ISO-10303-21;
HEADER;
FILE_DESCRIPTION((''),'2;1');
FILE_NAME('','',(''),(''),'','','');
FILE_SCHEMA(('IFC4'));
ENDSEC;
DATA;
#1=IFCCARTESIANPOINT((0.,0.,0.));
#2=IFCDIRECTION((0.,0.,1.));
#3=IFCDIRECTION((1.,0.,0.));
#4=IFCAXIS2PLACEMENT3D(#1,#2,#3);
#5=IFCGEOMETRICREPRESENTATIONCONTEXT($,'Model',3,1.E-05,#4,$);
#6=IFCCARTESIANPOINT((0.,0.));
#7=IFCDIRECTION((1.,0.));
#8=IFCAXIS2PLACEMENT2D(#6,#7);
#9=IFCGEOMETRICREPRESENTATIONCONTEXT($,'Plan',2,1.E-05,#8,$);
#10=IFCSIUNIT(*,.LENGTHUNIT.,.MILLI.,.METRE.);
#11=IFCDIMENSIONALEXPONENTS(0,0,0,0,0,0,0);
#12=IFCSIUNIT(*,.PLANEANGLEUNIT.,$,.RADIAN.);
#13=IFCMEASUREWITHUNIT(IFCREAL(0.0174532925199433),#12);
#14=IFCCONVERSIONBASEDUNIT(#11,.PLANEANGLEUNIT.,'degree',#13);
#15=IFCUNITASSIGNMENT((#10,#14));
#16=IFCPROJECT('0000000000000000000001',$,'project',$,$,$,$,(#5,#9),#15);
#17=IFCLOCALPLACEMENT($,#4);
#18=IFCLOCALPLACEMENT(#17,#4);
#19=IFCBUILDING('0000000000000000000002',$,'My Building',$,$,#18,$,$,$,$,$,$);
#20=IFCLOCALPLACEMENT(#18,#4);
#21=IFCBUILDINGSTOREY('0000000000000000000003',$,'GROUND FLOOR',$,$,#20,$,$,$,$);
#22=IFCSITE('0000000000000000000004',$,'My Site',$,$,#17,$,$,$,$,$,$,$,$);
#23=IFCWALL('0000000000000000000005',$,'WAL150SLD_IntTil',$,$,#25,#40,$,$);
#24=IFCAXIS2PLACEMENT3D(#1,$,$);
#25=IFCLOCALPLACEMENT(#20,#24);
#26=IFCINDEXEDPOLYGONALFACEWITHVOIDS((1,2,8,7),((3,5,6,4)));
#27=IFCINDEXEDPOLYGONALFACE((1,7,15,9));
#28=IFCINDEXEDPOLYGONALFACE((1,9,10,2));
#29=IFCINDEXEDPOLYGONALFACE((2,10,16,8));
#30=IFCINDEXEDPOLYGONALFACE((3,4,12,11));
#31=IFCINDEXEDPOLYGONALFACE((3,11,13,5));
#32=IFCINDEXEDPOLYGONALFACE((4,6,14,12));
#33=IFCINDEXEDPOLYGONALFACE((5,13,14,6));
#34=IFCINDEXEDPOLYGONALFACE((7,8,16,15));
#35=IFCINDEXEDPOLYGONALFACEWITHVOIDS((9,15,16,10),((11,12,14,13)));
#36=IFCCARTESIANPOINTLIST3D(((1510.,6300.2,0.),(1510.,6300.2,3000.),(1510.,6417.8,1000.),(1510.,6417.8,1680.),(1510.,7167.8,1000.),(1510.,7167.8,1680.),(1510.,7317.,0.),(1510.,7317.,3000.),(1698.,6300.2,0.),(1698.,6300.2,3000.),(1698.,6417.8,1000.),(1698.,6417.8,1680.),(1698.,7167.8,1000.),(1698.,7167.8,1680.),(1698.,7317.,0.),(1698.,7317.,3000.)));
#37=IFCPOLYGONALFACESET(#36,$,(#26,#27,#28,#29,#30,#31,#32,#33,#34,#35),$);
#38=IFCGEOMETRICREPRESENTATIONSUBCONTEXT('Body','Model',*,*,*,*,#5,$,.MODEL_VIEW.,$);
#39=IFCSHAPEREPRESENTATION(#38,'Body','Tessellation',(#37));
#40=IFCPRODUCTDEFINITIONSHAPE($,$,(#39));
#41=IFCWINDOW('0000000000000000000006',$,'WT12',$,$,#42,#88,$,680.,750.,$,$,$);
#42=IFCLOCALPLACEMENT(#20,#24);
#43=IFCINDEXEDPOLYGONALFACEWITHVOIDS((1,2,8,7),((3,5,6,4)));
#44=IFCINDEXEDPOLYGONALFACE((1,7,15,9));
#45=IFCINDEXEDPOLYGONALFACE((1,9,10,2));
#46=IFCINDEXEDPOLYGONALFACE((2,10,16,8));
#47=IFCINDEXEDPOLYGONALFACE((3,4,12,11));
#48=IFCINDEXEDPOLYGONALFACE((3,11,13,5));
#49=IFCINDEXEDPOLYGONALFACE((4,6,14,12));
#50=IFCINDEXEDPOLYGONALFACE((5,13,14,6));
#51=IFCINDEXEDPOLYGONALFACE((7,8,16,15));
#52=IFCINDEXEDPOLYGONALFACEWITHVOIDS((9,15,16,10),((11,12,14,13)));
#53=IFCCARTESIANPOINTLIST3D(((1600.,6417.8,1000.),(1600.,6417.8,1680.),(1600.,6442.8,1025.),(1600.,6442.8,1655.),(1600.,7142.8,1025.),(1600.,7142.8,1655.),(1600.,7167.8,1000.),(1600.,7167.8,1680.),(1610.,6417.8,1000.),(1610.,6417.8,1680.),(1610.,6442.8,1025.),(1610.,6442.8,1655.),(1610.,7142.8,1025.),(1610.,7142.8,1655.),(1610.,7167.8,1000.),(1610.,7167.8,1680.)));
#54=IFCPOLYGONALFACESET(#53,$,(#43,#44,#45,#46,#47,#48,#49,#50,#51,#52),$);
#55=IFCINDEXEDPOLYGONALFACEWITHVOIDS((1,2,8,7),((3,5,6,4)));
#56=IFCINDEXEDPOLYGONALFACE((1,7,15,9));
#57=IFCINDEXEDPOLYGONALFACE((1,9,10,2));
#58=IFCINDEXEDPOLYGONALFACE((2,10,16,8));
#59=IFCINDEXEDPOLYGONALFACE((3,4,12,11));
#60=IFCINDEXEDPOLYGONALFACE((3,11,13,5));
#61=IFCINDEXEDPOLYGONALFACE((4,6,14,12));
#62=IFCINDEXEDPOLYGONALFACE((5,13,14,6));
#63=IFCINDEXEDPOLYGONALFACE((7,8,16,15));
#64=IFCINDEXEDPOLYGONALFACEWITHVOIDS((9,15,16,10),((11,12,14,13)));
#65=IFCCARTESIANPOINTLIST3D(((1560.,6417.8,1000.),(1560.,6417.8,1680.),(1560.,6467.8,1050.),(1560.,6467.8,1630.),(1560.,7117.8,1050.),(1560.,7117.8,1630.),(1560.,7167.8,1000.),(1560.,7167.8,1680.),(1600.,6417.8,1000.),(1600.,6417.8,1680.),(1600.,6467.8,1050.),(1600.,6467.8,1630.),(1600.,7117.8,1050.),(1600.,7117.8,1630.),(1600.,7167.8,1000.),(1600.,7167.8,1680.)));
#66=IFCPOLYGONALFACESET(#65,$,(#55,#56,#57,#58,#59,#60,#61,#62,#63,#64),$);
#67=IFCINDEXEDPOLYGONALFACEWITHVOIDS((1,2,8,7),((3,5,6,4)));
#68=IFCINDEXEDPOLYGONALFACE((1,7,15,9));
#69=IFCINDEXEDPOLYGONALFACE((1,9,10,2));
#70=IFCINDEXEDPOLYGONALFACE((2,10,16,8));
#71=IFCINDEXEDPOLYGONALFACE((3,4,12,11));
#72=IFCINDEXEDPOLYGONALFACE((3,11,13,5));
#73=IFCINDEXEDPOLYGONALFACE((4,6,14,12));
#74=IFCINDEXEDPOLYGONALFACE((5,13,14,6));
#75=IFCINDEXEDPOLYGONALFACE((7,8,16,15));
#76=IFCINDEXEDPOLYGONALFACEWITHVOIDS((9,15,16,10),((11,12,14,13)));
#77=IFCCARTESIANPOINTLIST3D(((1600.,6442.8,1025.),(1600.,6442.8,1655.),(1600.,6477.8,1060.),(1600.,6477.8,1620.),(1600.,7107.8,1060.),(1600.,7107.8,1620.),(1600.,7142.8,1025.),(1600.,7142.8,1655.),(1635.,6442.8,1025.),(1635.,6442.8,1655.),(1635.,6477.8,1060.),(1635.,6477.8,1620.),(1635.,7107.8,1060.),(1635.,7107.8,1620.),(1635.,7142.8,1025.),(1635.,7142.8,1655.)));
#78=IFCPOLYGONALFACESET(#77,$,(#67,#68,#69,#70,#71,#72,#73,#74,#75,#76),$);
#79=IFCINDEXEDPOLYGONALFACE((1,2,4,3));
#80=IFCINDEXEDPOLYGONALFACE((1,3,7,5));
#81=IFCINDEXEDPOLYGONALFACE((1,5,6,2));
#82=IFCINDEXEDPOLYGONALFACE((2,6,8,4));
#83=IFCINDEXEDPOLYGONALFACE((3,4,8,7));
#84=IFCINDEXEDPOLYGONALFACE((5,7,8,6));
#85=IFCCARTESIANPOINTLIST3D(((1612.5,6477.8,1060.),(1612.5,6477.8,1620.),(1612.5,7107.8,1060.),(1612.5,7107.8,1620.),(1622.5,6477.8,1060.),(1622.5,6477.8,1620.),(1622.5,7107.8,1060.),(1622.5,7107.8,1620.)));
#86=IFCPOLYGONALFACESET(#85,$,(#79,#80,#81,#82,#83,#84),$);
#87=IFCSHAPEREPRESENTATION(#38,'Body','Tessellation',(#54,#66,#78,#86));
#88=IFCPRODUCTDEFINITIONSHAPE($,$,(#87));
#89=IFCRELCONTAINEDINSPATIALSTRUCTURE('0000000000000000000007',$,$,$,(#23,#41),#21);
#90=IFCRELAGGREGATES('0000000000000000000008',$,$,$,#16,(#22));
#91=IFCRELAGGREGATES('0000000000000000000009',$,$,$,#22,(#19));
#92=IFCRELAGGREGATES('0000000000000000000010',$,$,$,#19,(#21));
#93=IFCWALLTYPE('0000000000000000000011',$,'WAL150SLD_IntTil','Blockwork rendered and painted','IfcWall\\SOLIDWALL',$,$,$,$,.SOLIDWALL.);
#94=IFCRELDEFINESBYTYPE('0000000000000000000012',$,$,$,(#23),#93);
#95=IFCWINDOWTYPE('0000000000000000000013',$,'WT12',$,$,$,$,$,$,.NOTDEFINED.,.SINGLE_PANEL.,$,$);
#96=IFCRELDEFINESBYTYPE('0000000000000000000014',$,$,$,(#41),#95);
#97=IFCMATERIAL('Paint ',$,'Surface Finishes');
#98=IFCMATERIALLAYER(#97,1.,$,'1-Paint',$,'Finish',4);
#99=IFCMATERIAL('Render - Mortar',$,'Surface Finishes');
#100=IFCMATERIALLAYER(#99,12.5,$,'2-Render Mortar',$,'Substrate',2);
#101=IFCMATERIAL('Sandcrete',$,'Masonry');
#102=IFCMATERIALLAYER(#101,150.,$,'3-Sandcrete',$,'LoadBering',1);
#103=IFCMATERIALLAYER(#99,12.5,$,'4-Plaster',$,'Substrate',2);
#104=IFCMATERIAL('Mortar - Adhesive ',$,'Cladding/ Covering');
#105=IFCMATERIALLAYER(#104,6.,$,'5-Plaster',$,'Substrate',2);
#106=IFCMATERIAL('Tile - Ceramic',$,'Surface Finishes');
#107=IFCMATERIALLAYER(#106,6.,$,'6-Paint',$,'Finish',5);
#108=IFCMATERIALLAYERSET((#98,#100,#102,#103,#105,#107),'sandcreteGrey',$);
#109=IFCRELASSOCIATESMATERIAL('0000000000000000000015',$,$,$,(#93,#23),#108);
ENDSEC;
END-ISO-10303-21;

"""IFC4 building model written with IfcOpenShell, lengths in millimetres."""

from ifc_helpers import new_model, entity, si_unit, converted_unit, frame, origin_with_axes, origin_2d_with_axis, place, context, subcontext, project, spatial, line, indexed_curve, outline, extrude, shape, source, transform, mapped, material, layer, layer_set, layer_usage, type_object, type_shapes, element, fill, save


model = new_model("IFC4")

# Units and contexts
model_context = context("Model", 3, precision=1e-05, world=origin_with_axes())
plan_context = context("Plan", 2, precision=1e-05, world=origin_2d_with_axis())
body_context_1 = subcontext(model_context, "Body", "Model", "MODEL_VIEW")
body_context_2 = subcontext(plan_context, "Body", "Plan", "PLAN_VIEW")
ifc_project = project(units=[si_unit("LENGTHUNIT", "METRE", prefix="MILLI"), converted_unit("PLANEANGLEUNIT", "degree", entity("IfcReal", 0.0174532925199433), si_unit("PLANEANGLEUNIT", "RADIAN"), dimensions=[0, 0, 0, 0, 0, 0, 0])], contexts=[model_context, plan_context])

# Site, building, storey
site_placement = place(None, origin_with_axes())
site = spatial("IfcSite", under=ifc_project, at=site_placement, Name="My Site")
building_placement = place(site_placement, origin_with_axes())
building = spatial("IfcBuilding", under=site, at=building_placement, Name="My Building")
storey_placement = place(building_placement, origin_with_axes())
storey = spatial("IfcBuildingStorey", under=building, at=storey_placement, Name="GROUND FLOOR")

# Shared definitions
ifc_material_1 = material(Name="Paint ", Category="Surface Finishes")
ifc_material_2 = material(Name="Render - Mortar", Category="Surface Finishes")
ifc_material_3 = material(Name="Sandcrete", Category="Masonry")
ifc_material_4 = material(Name="Mortar - Adhesive ", Category="Cladding/ Covering")
ifc_material_5 = material(Name="Tile - Ceramic", Category="Surface Finishes")

# Wall, opening, window
ifc_layer_1 = layer(ifc_material_1, 1.0, Name="1-Paint", Category="Finish", Priority=4)
ifc_layer_2 = layer(ifc_material_2, 12.5, Name="2-Render Mortar", Category="Substrate", Priority=2)
ifc_layer_3 = layer(ifc_material_3, 150.0, Name="3-Sandcrete", Category="LoadBering", Priority=1)
ifc_layer_4 = layer(ifc_material_2, 12.5, Name="4-Plaster", Category="Substrate", Priority=2)
ifc_layer_5 = layer(ifc_material_4, 6.0, Name="5-Plaster", Category="Substrate", Priority=2)
ifc_layer_6 = layer(ifc_material_5, 6.0, Name="6-Paint", Category="Finish", Priority=5)
ifc_layer_set_1 = layer_set([ifc_layer_1, ifc_layer_2, ifc_layer_3, ifc_layer_4, ifc_layer_5, ifc_layer_6], Name="sandcreteGrey")
ifc_layer_usage_1 = layer_usage(ifc_layer_set_1, "AXIS2", "POSITIVE", 0.0)
wall_type_1 = type_object("IfcWallType", Name="WAL150SLD_IntTil", Description="Blockwork rendered and painted", ApplicableOccurrence="IfcWall\\SOLIDWALL", PredefinedType="SOLIDWALL", material=ifc_layer_set_1)
wall_1_placement = place(storey_placement, frame((1510.0, 7317.0, 0.0), z_axis=(0.0, 0.0, 1.0), x_axis=(-0.000001, -1.0, 0.0)))
wall_1 = element("IfcWall", 1, at=wall_1_placement, inside=storey, type_object=wall_type_1, material=ifc_layer_usage_1, Name="WAL150SLD_IntTil", context=body_context_1, shape_type="SweptSolid", body=[
    extrude(outline(indexed_curve([(0.0, 0.0), (0.0, 188.0), (1016.8, 188.0), (1016.8, 0.0), (0.0, 0.0)], self_intersect=False)), origin_with_axes(), (0.0, 0.0, 1.0), 3000.0),
])
shared_shape_1 = source(origin_with_axes(), body_context_1, "Body", "SweptSolid", [
    extrude(outline(indexed_curve([(0.0, 0.0), (750.0, 0.0), (750.0, 680.0), (0.0, 680.0)], segments=[line(1, 2, 3, 4, 1)])), frame((0.0, -600.0, 0.0), z_axis=(0.0, -1.0, 0.0), x_axis=(1.0, 0.0, 0.0)), (0.0, 0.0, -1.0), 1200.0),
])
opening_1_placement = place(wall_1_placement, frame((149.2, 0.0, 1000.0), z_axis=(0.0, 0.0, 1.0), x_axis=(1.0, 0.0, 0.0)))
opening_1 = element("IfcOpeningElement", 2, at=opening_1_placement, cuts=wall_1, PredefinedType="OPENING", context=body_context_1, shape_type="MappedRepresentation", body=[
    mapped(shared_shape_1, transform((0.0, 0.0, 0.0), x_axis=(1.0, 0.0, 0.0), y_axis=(0.0, 1.0, 0.0), z_axis=(0.0, 0.0, 1.0), scale=1.0)),
])
window_type_1 = type_object("IfcWindowType", Name="WT12", PartitioningType="SINGLE_PANEL", PredefinedType="NOTDEFINED")
shared_shape_2 = source(origin_with_axes(), body_context_1, "Body", "SweptSolid", [
    extrude(outline(indexed_curve([(0.0, 0.0), (750.0, 0.0), (750.0, 680.0), (0.0, 680.0)], segments=[line(1, 2, 3, 4, 1)]), holes=[indexed_curve([(25.0, 25.0), (725.0, 25.0), (725.0, 655.0), (25.0, 655.0)], segments=[line(1, 2, 3, 4, 1)])]), frame((0.0, 90.0, 0.0), z_axis=(0.0, -1.0, 0.0), x_axis=(1.0, 0.0, 0.0)), (0.0, 0.0, -1.0), 10.0),
    extrude(outline(indexed_curve([(0.0, 0.0), (750.0, 0.0), (750.0, 680.0), (0.0, 680.0)], segments=[line(1, 2, 3, 4, 1)]), holes=[indexed_curve([(50.0, 50.0), (700.0, 50.0), (700.0, 630.0), (50.0, 630.0)], segments=[line(1, 2, 3, 4, 1)])]), frame((0.0, 50.0, 0.0), z_axis=(0.0, -1.0, 0.0), x_axis=(1.0, 0.0, 0.0)), (0.0, 0.0, -1.0), 40.0),
    extrude(outline(indexed_curve([(0.0, 0.0), (700.0, 0.0), (700.0, 630.0), (0.0, 630.0)], segments=[line(1, 2, 3, 4, 1)]), holes=[indexed_curve([(35.0, 35.0), (665.0, 35.0), (665.0, 595.0), (35.0, 595.0)], segments=[line(1, 2, 3, 4, 1)])]), frame((25.0, 90.0, 25.0), z_axis=(0.0, -1.0, 0.0), x_axis=(1.0, 0.0, 0.0)), (0.0, 0.0, -1.0), 35.0),
    extrude(outline(indexed_curve([(35.0, 35.0), (665.0, 35.0), (665.0, 595.0), (35.0, 595.0)], segments=[line(1, 2, 3, 4, 1)])), frame((25.0, 102.5, 25.0), z_axis=(0.0, -1.0, 0.0), x_axis=(1.0, 0.0, 0.0)), (0.0, 0.0, -1.0), 10.0),
])
shared_shape_3 = source(origin_with_axes(), body_context_2, "Body", "Curve2D", [
    entity("IfcIndexedPolyCurve", entity("IfcCartesianPointList2D", [[50.0, 50.0], [700.0, 50.0]])),
    entity("IfcIndexedPolyCurve", entity("IfcCartesianPointList2D", [[0.0, 100.0], [25.0, 100.0], [25.0, 90.0], [50.0, 90.0], [50.0, 50.0], [0.0, 50.0]]), [entity("IfcLineIndex", [1, 2, 3, 4, 5, 6, 1])]),
    entity("IfcIndexedPolyCurve", entity("IfcCartesianPointList2D", [[750.0, 100.0], [725.0, 100.0], [725.0, 90.0], [700.0, 90.0], [700.0, 50.0], [750.0, 50.0]]), [entity("IfcLineIndex", [1, 2, 3, 4, 5, 6, 1])]),
    entity("IfcIndexedPolyCurve", entity("IfcCartesianPointList2D", [[25.0, 90.0], [60.0, 90.0], [60.0, 125.0], [25.0, 125.0]]), [entity("IfcLineIndex", [1, 2, 3, 4, 1])]),
    entity("IfcIndexedPolyCurve", entity("IfcCartesianPointList2D", [[725.0, 90.0], [690.0, 90.0], [690.0, 125.0], [725.0, 125.0]]), [entity("IfcLineIndex", [1, 2, 3, 4, 1])]),
    entity("IfcIndexedPolyCurve", entity("IfcCartesianPointList2D", [[60.0, 90.0], [690.0, 90.0]])),
    entity("IfcIndexedPolyCurve", entity("IfcCartesianPointList2D", [[60.0, 125.0], [690.0, 125.0]])),
    entity("IfcIndexedPolyCurve", entity("IfcCartesianPointList2D", [[60.0, 107.5], [690.0, 107.5]])),
])
type_shapes(window_type_1, [shared_shape_2, shared_shape_3])
window_1_placement = place(opening_1_placement, frame((0.0, 0.0, 0.0), z_axis=(0.0, 0.0, 1.0), x_axis=(1.0, 0.0, 0.0)))
window_1 = element("IfcWindow", 3, at=window_1_placement, inside=storey, type_object=window_type_1, Name="WT12", OverallHeight=680.0, OverallWidth=750.0, shapes=[
    shape(body_context_1, "Body", "MappedRepresentation", [mapped(shared_shape_2, transform((0.0, 0.0, 0.0), x_axis=(1.0, 0.0, 0.0), y_axis=(0.0, 1.0, 0.0), z_axis=(0.0, 0.0, 1.0), scale=1.0))]),
    shape(body_context_2, "Body", "MappedRepresentation", [mapped(shared_shape_3, transform((0.0, 0.0, 0.0), x_axis=(1.0, 0.0, 0.0), y_axis=(0.0, 1.0, 0.0), z_axis=(0.0, 0.0, 1.0), scale=1.0))]),
])
fill(opening_1, window_1)

save(model, "model.ifc")
